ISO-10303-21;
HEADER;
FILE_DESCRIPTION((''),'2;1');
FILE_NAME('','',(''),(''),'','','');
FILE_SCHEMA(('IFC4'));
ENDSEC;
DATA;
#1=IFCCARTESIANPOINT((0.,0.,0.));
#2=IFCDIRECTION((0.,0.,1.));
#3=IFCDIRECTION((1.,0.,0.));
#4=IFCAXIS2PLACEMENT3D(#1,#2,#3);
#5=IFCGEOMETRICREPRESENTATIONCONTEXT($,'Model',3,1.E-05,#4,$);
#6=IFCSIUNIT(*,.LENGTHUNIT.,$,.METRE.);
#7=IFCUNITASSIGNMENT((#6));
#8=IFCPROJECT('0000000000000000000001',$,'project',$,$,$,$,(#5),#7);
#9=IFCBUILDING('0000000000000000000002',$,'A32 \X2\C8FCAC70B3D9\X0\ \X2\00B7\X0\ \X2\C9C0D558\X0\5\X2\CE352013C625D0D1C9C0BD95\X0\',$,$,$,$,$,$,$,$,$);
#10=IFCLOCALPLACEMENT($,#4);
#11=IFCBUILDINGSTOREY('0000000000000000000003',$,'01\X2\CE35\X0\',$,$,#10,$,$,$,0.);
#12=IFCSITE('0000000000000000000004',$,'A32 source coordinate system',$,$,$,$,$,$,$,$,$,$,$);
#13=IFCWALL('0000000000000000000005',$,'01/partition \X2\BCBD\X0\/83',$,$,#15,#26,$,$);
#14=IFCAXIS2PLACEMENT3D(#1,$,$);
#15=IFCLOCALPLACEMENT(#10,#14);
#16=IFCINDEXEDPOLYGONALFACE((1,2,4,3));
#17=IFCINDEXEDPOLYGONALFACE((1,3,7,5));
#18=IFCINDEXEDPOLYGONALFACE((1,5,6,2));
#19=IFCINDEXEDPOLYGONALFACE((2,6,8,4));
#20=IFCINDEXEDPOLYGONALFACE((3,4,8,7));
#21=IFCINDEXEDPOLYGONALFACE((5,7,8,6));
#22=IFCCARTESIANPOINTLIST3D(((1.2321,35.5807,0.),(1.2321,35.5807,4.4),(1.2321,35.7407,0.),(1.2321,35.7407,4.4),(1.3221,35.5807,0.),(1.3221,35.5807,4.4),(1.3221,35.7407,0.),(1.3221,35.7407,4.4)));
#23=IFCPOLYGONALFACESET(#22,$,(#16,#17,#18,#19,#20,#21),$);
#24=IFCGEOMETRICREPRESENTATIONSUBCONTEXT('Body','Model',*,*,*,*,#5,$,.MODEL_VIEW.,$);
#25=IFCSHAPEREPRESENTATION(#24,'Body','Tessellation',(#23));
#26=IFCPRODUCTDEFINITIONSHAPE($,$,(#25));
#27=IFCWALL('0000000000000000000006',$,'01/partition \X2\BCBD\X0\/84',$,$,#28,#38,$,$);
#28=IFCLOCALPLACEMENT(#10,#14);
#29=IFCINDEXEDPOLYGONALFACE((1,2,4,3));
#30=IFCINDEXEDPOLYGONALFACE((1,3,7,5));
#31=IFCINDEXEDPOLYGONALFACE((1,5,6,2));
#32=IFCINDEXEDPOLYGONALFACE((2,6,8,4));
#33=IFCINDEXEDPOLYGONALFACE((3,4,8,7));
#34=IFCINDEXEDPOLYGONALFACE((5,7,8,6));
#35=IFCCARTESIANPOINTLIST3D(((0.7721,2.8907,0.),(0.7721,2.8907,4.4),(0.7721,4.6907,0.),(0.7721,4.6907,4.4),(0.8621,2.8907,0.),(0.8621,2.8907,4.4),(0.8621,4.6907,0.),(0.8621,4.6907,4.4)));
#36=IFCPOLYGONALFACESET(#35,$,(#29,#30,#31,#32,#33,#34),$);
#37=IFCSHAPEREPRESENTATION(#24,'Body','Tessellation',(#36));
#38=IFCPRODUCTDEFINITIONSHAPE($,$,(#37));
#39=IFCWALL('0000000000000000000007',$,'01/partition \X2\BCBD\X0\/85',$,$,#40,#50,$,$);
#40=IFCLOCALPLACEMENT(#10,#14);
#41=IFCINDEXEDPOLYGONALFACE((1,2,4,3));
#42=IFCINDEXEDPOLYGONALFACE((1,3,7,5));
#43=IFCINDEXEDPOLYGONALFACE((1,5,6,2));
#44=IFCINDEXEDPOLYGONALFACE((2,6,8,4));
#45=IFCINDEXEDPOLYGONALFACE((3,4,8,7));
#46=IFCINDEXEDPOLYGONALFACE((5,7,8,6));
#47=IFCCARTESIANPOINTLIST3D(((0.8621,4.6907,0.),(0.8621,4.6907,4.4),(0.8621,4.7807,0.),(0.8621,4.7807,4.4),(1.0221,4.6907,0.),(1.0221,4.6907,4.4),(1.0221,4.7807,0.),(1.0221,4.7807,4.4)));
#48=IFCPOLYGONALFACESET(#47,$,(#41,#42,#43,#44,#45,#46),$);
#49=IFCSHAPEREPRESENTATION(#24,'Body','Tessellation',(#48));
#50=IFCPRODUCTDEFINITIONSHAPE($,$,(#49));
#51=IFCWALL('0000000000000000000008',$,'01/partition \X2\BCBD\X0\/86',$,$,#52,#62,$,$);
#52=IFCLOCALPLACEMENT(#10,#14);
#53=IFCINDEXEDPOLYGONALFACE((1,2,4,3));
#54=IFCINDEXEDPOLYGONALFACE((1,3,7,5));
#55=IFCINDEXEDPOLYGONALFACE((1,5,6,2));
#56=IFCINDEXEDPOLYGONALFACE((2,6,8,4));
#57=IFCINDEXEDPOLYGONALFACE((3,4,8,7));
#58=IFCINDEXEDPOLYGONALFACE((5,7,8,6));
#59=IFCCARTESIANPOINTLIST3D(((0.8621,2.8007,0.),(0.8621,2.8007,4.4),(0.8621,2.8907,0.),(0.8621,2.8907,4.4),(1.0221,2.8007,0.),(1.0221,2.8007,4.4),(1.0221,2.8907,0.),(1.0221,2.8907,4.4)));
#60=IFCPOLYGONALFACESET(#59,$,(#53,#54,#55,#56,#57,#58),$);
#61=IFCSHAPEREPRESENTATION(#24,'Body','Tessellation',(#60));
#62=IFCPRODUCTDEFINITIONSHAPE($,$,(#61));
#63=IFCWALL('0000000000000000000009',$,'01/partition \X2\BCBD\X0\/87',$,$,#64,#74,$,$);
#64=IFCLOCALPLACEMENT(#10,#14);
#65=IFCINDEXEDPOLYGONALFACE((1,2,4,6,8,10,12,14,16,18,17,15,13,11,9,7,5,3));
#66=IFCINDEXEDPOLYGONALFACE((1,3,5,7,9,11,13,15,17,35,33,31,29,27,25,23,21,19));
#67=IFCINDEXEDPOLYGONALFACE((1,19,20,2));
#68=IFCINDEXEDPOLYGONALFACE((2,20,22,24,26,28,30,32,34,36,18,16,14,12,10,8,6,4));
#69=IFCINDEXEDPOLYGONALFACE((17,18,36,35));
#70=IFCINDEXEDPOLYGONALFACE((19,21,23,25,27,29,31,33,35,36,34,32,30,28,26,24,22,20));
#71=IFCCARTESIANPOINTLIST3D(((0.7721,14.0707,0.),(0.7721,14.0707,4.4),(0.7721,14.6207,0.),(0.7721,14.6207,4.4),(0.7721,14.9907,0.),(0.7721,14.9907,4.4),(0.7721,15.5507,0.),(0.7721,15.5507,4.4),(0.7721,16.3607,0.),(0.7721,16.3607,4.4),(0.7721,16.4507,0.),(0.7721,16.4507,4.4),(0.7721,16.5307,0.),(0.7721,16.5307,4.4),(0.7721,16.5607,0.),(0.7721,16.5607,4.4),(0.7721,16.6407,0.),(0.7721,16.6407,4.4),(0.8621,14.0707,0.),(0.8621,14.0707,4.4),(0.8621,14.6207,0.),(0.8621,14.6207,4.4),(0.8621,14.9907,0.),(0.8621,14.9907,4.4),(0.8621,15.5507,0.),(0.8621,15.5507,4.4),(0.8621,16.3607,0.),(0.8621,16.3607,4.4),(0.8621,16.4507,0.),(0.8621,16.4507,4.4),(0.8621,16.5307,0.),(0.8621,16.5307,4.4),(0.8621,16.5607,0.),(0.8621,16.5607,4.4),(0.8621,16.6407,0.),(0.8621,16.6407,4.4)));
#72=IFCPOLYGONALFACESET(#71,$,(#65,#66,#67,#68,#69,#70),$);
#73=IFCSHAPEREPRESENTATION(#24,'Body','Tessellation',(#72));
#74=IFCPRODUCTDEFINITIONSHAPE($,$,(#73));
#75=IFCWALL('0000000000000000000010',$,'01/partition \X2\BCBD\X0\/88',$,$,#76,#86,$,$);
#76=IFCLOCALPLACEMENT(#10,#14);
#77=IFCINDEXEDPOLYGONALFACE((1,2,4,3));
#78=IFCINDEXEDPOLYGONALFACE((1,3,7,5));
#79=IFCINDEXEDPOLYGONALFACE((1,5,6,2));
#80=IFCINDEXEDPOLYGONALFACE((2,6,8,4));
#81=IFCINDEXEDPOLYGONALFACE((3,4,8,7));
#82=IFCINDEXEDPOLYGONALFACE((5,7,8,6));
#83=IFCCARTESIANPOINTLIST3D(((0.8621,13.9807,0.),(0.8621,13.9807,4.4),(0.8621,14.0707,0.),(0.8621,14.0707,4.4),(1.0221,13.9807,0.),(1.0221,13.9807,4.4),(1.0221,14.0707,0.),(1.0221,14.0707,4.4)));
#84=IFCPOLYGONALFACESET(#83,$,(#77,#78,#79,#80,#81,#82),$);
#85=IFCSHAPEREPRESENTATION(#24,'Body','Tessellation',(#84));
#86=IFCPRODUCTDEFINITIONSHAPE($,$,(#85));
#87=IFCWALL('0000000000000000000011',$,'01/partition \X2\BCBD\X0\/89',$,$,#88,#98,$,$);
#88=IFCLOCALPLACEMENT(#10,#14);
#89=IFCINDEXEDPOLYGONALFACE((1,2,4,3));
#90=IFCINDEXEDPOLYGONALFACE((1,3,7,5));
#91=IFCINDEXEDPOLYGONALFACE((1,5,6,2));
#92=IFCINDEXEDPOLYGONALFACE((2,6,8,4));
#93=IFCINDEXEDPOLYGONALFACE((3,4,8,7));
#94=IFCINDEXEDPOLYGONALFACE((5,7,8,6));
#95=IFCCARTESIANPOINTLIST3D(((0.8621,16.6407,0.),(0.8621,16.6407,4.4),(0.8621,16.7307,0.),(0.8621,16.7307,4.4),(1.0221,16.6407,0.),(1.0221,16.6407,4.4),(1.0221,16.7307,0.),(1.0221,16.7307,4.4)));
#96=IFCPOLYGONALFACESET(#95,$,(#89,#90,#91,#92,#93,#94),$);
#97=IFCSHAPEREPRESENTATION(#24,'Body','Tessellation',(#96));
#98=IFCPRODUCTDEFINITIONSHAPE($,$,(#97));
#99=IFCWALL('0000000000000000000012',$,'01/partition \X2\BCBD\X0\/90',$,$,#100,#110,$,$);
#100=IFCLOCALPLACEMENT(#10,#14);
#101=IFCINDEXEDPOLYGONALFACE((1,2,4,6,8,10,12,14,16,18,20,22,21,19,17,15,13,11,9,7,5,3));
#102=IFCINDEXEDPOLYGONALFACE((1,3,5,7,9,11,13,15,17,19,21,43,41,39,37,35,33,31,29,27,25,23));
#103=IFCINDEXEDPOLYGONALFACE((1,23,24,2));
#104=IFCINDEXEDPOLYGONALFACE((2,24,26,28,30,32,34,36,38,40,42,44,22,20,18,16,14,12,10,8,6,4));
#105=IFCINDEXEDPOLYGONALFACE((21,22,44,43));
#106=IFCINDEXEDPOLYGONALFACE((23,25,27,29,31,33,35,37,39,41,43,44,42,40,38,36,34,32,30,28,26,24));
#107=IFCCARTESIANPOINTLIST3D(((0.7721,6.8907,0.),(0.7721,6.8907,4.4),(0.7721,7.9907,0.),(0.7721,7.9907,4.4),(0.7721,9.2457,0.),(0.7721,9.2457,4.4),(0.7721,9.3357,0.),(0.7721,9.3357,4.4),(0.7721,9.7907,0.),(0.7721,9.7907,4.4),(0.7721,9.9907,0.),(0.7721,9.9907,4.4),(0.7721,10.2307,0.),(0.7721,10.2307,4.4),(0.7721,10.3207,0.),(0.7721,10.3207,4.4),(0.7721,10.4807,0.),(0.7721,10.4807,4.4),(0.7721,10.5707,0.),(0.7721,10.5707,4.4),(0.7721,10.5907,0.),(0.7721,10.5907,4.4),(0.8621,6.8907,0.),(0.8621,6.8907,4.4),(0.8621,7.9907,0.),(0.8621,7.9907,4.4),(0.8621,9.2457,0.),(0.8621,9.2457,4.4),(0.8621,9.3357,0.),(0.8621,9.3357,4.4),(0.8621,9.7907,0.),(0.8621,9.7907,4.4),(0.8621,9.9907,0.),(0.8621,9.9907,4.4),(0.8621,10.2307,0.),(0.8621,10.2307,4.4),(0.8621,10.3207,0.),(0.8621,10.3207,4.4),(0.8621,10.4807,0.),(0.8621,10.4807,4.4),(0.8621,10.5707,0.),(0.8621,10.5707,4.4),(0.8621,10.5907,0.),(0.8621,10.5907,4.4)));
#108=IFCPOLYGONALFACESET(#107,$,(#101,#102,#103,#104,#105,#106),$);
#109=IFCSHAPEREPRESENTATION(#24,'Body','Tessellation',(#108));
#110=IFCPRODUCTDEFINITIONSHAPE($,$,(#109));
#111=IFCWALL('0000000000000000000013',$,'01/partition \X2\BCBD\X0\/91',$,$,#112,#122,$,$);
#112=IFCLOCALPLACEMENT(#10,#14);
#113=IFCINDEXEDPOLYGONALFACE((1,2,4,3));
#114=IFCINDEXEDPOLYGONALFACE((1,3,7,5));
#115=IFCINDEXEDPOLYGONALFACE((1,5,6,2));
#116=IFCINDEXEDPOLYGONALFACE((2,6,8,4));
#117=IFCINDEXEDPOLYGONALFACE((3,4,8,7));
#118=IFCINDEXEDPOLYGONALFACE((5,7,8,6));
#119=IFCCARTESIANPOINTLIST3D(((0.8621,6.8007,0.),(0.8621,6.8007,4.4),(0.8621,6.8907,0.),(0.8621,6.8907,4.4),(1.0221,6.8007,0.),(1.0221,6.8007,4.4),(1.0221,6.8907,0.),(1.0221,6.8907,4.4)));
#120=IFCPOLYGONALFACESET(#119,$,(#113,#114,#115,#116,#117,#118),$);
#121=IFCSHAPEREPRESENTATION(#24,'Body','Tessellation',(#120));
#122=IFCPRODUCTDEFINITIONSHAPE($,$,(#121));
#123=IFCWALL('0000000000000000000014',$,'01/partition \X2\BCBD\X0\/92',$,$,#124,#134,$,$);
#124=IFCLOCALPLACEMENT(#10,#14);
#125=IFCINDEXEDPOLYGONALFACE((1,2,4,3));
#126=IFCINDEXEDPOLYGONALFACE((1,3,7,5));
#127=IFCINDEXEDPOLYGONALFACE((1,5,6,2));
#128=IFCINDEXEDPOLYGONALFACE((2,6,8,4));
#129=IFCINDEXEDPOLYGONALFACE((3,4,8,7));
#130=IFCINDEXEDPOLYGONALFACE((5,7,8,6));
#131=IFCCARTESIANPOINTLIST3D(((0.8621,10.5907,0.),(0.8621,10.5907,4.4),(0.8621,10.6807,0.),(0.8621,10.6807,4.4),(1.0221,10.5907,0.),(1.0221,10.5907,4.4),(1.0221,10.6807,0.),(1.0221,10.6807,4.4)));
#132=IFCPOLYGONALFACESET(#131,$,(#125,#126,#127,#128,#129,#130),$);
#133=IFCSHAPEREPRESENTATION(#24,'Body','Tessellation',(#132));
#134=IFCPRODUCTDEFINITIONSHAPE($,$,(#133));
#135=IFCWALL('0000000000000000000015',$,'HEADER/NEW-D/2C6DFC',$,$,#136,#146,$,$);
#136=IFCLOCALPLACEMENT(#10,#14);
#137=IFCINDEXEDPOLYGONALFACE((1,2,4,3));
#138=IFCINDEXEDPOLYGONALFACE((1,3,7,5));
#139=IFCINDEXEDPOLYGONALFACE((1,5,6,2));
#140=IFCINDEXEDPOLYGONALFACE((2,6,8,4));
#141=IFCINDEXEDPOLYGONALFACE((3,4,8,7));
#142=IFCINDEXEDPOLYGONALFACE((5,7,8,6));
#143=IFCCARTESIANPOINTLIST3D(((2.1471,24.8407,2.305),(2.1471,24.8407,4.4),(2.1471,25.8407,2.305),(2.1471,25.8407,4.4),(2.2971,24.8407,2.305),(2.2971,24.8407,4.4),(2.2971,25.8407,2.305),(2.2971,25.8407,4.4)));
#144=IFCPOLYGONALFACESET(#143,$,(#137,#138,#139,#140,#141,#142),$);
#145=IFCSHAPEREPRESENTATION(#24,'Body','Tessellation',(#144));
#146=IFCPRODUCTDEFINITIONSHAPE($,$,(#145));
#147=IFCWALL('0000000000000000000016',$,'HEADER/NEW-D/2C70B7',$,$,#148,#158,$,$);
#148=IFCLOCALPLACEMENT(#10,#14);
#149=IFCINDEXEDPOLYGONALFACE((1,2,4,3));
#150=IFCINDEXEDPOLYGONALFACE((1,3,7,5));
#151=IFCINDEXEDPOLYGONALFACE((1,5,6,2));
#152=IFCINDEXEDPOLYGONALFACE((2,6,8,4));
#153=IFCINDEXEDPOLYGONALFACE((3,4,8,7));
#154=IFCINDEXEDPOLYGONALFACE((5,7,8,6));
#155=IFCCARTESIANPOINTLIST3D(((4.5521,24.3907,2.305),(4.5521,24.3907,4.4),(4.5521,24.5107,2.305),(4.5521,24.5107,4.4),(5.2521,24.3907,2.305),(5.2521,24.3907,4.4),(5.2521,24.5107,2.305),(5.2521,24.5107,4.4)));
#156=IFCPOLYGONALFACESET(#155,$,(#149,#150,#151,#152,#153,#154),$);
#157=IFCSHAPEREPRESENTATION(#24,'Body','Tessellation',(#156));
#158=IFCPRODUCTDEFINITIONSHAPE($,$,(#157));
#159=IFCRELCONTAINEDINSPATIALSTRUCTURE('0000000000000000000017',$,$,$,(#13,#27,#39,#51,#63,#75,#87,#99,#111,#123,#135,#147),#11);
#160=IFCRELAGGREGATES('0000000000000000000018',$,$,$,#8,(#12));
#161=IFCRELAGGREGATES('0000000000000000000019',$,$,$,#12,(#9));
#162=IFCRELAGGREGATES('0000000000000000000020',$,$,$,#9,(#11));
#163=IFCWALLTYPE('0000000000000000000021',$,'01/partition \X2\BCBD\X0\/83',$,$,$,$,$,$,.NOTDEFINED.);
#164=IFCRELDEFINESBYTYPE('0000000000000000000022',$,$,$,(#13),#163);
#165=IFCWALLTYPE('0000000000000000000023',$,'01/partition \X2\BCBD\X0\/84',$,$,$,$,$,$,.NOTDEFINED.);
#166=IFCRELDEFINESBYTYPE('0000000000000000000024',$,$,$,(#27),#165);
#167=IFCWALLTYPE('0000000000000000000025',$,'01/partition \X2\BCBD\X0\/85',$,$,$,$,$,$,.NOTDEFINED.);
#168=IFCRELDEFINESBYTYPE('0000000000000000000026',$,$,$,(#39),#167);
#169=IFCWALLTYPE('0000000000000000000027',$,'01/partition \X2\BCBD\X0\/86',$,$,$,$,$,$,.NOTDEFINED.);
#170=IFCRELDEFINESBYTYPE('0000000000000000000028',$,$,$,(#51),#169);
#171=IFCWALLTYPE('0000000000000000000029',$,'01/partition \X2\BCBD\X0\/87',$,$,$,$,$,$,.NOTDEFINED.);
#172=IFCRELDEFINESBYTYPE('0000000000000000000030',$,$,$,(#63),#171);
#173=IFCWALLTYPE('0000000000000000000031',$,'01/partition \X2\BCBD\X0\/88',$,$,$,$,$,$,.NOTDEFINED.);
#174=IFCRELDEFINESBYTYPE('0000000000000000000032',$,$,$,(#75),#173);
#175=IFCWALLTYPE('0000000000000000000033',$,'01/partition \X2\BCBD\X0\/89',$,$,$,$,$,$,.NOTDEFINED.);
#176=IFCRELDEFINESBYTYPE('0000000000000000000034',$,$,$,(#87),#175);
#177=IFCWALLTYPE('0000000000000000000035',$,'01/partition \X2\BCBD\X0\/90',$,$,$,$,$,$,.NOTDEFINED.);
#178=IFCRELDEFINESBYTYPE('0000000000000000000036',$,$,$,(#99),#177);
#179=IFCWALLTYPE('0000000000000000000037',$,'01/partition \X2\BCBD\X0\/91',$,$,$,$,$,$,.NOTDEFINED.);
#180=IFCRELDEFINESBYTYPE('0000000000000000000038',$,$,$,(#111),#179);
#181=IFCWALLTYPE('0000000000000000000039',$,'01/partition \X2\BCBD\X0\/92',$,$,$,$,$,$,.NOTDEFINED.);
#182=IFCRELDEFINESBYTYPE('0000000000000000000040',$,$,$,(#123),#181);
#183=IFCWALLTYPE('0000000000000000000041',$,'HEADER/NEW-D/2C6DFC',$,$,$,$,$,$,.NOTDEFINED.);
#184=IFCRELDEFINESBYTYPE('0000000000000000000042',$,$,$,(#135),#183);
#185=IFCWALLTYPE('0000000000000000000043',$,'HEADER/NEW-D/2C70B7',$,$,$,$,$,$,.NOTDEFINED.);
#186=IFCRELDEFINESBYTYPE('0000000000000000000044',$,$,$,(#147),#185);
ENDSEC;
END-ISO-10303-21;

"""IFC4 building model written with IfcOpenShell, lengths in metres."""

from ifc_helpers import new_model, si_unit, frame, origin, origin_with_axes, place, context, subcontext, project, spatial, polyline, outline, extrude, source, transform, mapped, type_object, type_shapes, element, save


model = new_model("IFC4")

# Units and contexts
model_context = context("Model", 3, precision=1e-05, world=origin_with_axes())
body_context = subcontext(model_context, "Body", "Model", "MODEL_VIEW")
ifc_project = project(units=[si_unit("LENGTHUNIT", "METRE")], contexts=[model_context])

# Site, building, storey
site = spatial("IfcSite", under=ifc_project, Name="A32 source coordinate system")
building = spatial("IfcBuilding", under=site, Name="A32 주거동 · 지하5층–옥탑지붕")
storey_placement = place(None, origin_with_axes())
storey = spatial("IfcBuildingStorey", under=building, at=storey_placement, Name="01층", Elevation=0.0)

# Walls
wall_type_1 = type_object("IfcWallType", Name="01/partition 벽/83", PredefinedType="NOTDEFINED")
shared_shape_1 = source(origin(), body_context, "Body", "SweptSolid", [
    extrude(outline(polyline([(1.3221, 35.7407), (1.3221, 35.5807), (1.2321, 35.5807), (1.2321, 35.7407), (1.3221, 35.7407)])), origin(), (0.0, 0.0, 1.0), 4.4),
])
type_shapes(wall_type_1, [shared_shape_1])
wall_1_placement = place(storey_placement, origin_with_axes())
element("IfcWall", 1, at=wall_1_placement, inside=storey, type_object=wall_type_1, Name="01/partition 벽/83", context=body_context, shape_type="MappedRepresentation", body=[
    mapped(shared_shape_1, transform((0.0, 0.0, 0.0), scale=1.0)),
])
wall_type_2 = type_object("IfcWallType", Name="01/partition 벽/84", PredefinedType="NOTDEFINED")
shared_shape_2 = source(origin(), body_context, "Body", "SweptSolid", [
    extrude(outline(polyline([(0.7721, 4.6907), (0.8621, 4.6907), (0.8621, 2.8907), (0.7721, 2.8907), (0.7721, 4.6907)])), origin(), (0.0, 0.0, 1.0), 4.4),
])
type_shapes(wall_type_2, [shared_shape_2])
wall_2_placement = place(storey_placement, origin_with_axes())
element("IfcWall", 2, at=wall_2_placement, inside=storey, type_object=wall_type_2, Name="01/partition 벽/84", context=body_context, shape_type="MappedRepresentation", body=[
    mapped(shared_shape_2, transform((0.0, 0.0, 0.0), scale=1.0)),
])
wall_type_3 = type_object("IfcWallType", Name="01/partition 벽/85", PredefinedType="NOTDEFINED")
shared_shape_3 = source(origin(), body_context, "Body", "SweptSolid", [
    extrude(outline(polyline([(0.8621, 4.7807), (1.0221, 4.7807), (1.0221, 4.6907), (0.8621, 4.6907), (0.8621, 4.7807)])), origin(), (0.0, 0.0, 1.0), 4.4),
])
type_shapes(wall_type_3, [shared_shape_3])
wall_3_placement = place(storey_placement, origin_with_axes())
element("IfcWall", 3, at=wall_3_placement, inside=storey, type_object=wall_type_3, Name="01/partition 벽/85", context=body_context, shape_type="MappedRepresentation", body=[
    mapped(shared_shape_3, transform((0.0, 0.0, 0.0), scale=1.0)),
])
wall_type_4 = type_object("IfcWallType", Name="01/partition 벽/86", PredefinedType="NOTDEFINED")
shared_shape_4 = source(origin(), body_context, "Body", "SweptSolid", [
    extrude(outline(polyline([(1.0221, 2.8907), (1.0221, 2.8007), (0.8621, 2.8007), (0.8621, 2.8907), (1.0221, 2.8907)])), origin(), (0.0, 0.0, 1.0), 4.4),
])
type_shapes(wall_type_4, [shared_shape_4])
wall_4_placement = place(storey_placement, origin_with_axes())
element("IfcWall", 4, at=wall_4_placement, inside=storey, type_object=wall_type_4, Name="01/partition 벽/86", context=body_context, shape_type="MappedRepresentation", body=[
    mapped(shared_shape_4, transform((0.0, 0.0, 0.0), scale=1.0)),
])
wall_type_5 = type_object("IfcWallType", Name="01/partition 벽/87", PredefinedType="NOTDEFINED")
shared_shape_5 = source(origin(), body_context, "Body", "SweptSolid", [
    extrude(outline(polyline([(0.7721, 16.5607), (0.7721, 16.6407), (0.8621, 16.6407), (0.8621, 16.5607), (0.8621, 16.5307), (0.8621, 16.4507), (0.8621, 16.3607), (0.8621, 15.5507), (0.8621, 14.9907), (0.8621, 14.6207), (0.8621, 14.0707), (0.7721, 14.0707), (0.7721, 14.6207), (0.7721, 14.9907), (0.7721, 15.5507), (0.7721, 16.3607), (0.7721, 16.4507), (0.7721, 16.5307), (0.7721, 16.5607)])), origin(), (0.0, 0.0, 1.0), 4.4),
])
type_shapes(wall_type_5, [shared_shape_5])
wall_5_placement = place(storey_placement, origin_with_axes())
element("IfcWall", 5, at=wall_5_placement, inside=storey, type_object=wall_type_5, Name="01/partition 벽/87", context=body_context, shape_type="MappedRepresentation", body=[
    mapped(shared_shape_5, transform((0.0, 0.0, 0.0), scale=1.0)),
])
wall_type_6 = type_object("IfcWallType", Name="01/partition 벽/88", PredefinedType="NOTDEFINED")
shared_shape_6 = source(origin(), body_context, "Body", "SweptSolid", [
    extrude(outline(polyline([(1.0221, 14.0707), (1.0221, 13.9807), (0.8621, 13.9807), (0.8621, 14.0707), (1.0221, 14.0707)])), origin(), (0.0, 0.0, 1.0), 4.4),
])
type_shapes(wall_type_6, [shared_shape_6])
wall_6_placement = place(storey_placement, origin_with_axes())
element("IfcWall", 6, at=wall_6_placement, inside=storey, type_object=wall_type_6, Name="01/partition 벽/88", context=body_context, shape_type="MappedRepresentation", body=[
    mapped(shared_shape_6, transform((0.0, 0.0, 0.0), scale=1.0)),
])
wall_type_7 = type_object("IfcWallType", Name="01/partition 벽/89", PredefinedType="NOTDEFINED")
shared_shape_7 = source(origin(), body_context, "Body", "SweptSolid", [
    extrude(outline(polyline([(0.8621, 16.7307), (1.0221, 16.7307), (1.0221, 16.6407), (0.8621, 16.6407), (0.8621, 16.7307)])), origin(), (0.0, 0.0, 1.0), 4.4),
])
type_shapes(wall_type_7, [shared_shape_7])
wall_7_placement = place(storey_placement, origin_with_axes())
element("IfcWall", 7, at=wall_7_placement, inside=storey, type_object=wall_type_7, Name="01/partition 벽/89", context=body_context, shape_type="MappedRepresentation", body=[
    mapped(shared_shape_7, transform((0.0, 0.0, 0.0), scale=1.0)),
])
wall_type_8 = type_object("IfcWallType", Name="01/partition 벽/90", PredefinedType="NOTDEFINED")
shared_shape_8 = source(origin(), body_context, "Body", "SweptSolid", [
    extrude(outline(polyline([(0.7721, 9.9907), (0.7721, 10.2307), (0.7721, 10.3207), (0.7721, 10.4807), (0.7721, 10.5707), (0.7721, 10.5907), (0.8621, 10.5907), (0.8621, 10.5707), (0.8621, 10.4807), (0.8621, 10.3207), (0.8621, 10.2307), (0.8621, 9.9907), (0.8621, 9.7907), (0.8621, 9.3357), (0.8621, 9.2457), (0.8621, 7.9907), (0.8621, 6.8907), (0.7721, 6.8907), (0.7721, 7.9907), (0.7721, 9.2457), (0.7721, 9.3357), (0.7721, 9.7907), (0.7721, 9.9907)])), origin(), (0.0, 0.0, 1.0), 4.4),
])
type_shapes(wall_type_8, [shared_shape_8])
wall_8_placement = place(storey_placement, origin_with_axes())
element("IfcWall", 8, at=wall_8_placement, inside=storey, type_object=wall_type_8, Name="01/partition 벽/90", context=body_context, shape_type="MappedRepresentation", body=[
    mapped(shared_shape_8, transform((0.0, 0.0, 0.0), scale=1.0)),
])
wall_type_9 = type_object("IfcWallType", Name="01/partition 벽/91", PredefinedType="NOTDEFINED")
shared_shape_9 = source(origin(), body_context, "Body", "SweptSolid", [
    extrude(outline(polyline([(1.0221, 6.8907), (1.0221, 6.8007), (0.8621, 6.8007), (0.8621, 6.8907), (1.0221, 6.8907)])), origin(), (0.0, 0.0, 1.0), 4.4),
])
type_shapes(wall_type_9, [shared_shape_9])
wall_9_placement = place(storey_placement, origin_with_axes())
element("IfcWall", 9, at=wall_9_placement, inside=storey, type_object=wall_type_9, Name="01/partition 벽/91", context=body_context, shape_type="MappedRepresentation", body=[
    mapped(shared_shape_9, transform((0.0, 0.0, 0.0), scale=1.0)),
])
wall_type_10 = type_object("IfcWallType", Name="01/partition 벽/92", PredefinedType="NOTDEFINED")
shared_shape_10 = source(origin(), body_context, "Body", "SweptSolid", [
    extrude(outline(polyline([(0.8621, 10.6807), (1.0221, 10.6807), (1.0221, 10.5907), (0.8621, 10.5907), (0.8621, 10.6807)])), origin(), (0.0, 0.0, 1.0), 4.4),
])
type_shapes(wall_type_10, [shared_shape_10])
wall_10_placement = place(storey_placement, origin_with_axes())
element("IfcWall", 10, at=wall_10_placement, inside=storey, type_object=wall_type_10, Name="01/partition 벽/92", context=body_context, shape_type="MappedRepresentation", body=[
    mapped(shared_shape_10, transform((0.0, 0.0, 0.0), scale=1.0)),
])
wall_type_11 = type_object("IfcWallType", Name="HEADER/NEW-D/2C6DFC", PredefinedType="NOTDEFINED")
shared_shape_11 = source(origin(), body_context, "Body", "SweptSolid", [
    extrude(outline(polyline([(2.1471, 24.8407), (2.1471, 25.8407), (2.2971, 25.8407), (2.2971, 24.8407), (2.1471, 24.8407)])), frame((0.0, 0.0, 2.305)), (0.0, 0.0, 1.0), 2.095),
])
type_shapes(wall_type_11, [shared_shape_11])
wall_11_placement = place(storey_placement, origin_with_axes())
element("IfcWall", 11, at=wall_11_placement, inside=storey, type_object=wall_type_11, Name="HEADER/NEW-D/2C6DFC", context=body_context, shape_type="MappedRepresentation", body=[
    mapped(shared_shape_11, transform((0.0, 0.0, 0.0), scale=1.0)),
])
wall_type_12 = type_object("IfcWallType", Name="HEADER/NEW-D/2C70B7", PredefinedType="NOTDEFINED")
shared_shape_12 = source(origin(), body_context, "Body", "SweptSolid", [
    extrude(outline(polyline([(4.5521, 24.3907), (4.5521, 24.5107), (5.2521, 24.5107), (5.2521, 24.3907), (4.5521, 24.3907)])), frame((0.0, 0.0, 2.305)), (0.0, 0.0, 1.0), 2.095),
])
type_shapes(wall_type_12, [shared_shape_12])
wall_12_placement = place(storey_placement, origin_with_axes())
element("IfcWall", 12, at=wall_12_placement, inside=storey, type_object=wall_type_12, Name="HEADER/NEW-D/2C70B7", context=body_context, shape_type="MappedRepresentation", body=[
    mapped(shared_shape_12, transform((0.0, 0.0, 0.0), scale=1.0)),
])

save(model, "model.ifc")
